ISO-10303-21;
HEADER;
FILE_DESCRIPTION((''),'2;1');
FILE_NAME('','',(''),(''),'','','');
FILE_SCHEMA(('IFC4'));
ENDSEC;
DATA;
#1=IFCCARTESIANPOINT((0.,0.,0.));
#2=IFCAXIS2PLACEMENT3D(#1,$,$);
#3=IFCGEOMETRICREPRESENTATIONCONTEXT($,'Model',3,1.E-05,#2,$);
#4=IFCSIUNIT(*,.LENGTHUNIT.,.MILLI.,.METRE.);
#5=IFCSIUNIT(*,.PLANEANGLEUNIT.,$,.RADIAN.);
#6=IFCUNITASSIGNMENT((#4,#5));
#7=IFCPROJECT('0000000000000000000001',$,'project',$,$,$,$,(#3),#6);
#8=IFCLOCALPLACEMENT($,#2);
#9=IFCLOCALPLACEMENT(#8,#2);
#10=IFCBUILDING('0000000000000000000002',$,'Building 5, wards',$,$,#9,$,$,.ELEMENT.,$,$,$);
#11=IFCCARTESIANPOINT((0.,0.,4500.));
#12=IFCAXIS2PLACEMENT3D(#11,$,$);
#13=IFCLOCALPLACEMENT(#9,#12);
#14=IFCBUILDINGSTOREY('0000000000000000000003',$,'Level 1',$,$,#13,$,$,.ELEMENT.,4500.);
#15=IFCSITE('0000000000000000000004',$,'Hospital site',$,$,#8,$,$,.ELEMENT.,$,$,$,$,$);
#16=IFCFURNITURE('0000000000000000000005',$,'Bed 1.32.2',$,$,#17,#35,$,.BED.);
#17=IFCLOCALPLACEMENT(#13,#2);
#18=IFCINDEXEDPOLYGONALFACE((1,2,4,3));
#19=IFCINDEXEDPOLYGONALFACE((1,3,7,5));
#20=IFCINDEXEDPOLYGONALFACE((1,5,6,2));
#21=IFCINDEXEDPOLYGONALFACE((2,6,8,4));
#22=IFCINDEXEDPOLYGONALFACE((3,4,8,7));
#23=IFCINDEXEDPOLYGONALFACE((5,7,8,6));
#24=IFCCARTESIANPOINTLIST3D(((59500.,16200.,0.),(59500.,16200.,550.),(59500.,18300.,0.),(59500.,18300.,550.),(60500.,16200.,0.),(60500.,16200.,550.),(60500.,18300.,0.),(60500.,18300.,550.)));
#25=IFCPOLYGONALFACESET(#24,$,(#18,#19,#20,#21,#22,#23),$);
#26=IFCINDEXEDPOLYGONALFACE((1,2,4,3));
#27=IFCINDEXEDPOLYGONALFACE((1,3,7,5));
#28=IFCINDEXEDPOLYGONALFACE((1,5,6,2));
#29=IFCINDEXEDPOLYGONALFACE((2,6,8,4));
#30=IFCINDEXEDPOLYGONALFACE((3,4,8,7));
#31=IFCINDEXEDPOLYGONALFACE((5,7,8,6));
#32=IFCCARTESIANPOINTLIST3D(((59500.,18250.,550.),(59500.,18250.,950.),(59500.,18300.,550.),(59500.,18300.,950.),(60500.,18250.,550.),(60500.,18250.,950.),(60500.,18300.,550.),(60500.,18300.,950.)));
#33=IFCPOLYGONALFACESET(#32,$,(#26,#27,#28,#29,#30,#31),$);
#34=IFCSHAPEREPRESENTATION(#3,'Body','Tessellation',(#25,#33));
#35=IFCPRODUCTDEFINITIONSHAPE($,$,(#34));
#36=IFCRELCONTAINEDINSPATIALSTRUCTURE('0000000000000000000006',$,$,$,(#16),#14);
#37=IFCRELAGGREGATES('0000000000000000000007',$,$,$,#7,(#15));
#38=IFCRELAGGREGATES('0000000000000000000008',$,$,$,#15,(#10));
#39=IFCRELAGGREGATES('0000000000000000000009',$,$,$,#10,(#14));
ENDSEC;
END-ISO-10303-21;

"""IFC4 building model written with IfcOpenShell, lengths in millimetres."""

from ifc_helpers import new_model, si_unit, frame, frame_2d, origin, place, context, project, spatial, rectangle, extrude, element, save


model = new_model("IFC4")

# Units and contexts
model_context = context("Model", 3, precision=1e-05, world=origin())
ifc_project = project(units=[si_unit("LENGTHUNIT", "METRE", prefix="MILLI"), si_unit("PLANEANGLEUNIT", "RADIAN")], contexts=[model_context])

# Site, building, storey
site_placement = place(None, origin())
site = spatial("IfcSite", under=ifc_project, at=site_placement, Name="Hospital site", CompositionType="ELEMENT")
building_placement = place(site_placement, origin())
building = spatial("IfcBuilding", under=site, at=building_placement, Name="Building 5, wards", CompositionType="ELEMENT")
storey_placement = place(building_placement, frame((0.0, 0.0, 4500.0)))
storey = spatial("IfcBuildingStorey", under=building, at=storey_placement, Name="Level 1", CompositionType="ELEMENT", Elevation=4500.0)

# Furniture
furniture_placement = place(storey_placement, frame((59500.0, 16200.0, 0.0)))
element("IfcFurniture", 1, at=furniture_placement, inside=storey, Name="Bed 1.32.2", PredefinedType="BED", context=model_context, shape_type="SweptSolid", body=[
    extrude(rectangle(XDim=1000.0, YDim=2100.0, at=frame_2d((500.0, 1050.0))), origin(), (0.0, 0.0, 1.0), 550.0),
    extrude(rectangle(XDim=1000.0, YDim=50.0, at=frame_2d((500.0, 2075.0))), frame((0.0, 0.0, 550.0)), (0.0, 0.0, 1.0), 400.0),
])

save(model, "model.ifc")
